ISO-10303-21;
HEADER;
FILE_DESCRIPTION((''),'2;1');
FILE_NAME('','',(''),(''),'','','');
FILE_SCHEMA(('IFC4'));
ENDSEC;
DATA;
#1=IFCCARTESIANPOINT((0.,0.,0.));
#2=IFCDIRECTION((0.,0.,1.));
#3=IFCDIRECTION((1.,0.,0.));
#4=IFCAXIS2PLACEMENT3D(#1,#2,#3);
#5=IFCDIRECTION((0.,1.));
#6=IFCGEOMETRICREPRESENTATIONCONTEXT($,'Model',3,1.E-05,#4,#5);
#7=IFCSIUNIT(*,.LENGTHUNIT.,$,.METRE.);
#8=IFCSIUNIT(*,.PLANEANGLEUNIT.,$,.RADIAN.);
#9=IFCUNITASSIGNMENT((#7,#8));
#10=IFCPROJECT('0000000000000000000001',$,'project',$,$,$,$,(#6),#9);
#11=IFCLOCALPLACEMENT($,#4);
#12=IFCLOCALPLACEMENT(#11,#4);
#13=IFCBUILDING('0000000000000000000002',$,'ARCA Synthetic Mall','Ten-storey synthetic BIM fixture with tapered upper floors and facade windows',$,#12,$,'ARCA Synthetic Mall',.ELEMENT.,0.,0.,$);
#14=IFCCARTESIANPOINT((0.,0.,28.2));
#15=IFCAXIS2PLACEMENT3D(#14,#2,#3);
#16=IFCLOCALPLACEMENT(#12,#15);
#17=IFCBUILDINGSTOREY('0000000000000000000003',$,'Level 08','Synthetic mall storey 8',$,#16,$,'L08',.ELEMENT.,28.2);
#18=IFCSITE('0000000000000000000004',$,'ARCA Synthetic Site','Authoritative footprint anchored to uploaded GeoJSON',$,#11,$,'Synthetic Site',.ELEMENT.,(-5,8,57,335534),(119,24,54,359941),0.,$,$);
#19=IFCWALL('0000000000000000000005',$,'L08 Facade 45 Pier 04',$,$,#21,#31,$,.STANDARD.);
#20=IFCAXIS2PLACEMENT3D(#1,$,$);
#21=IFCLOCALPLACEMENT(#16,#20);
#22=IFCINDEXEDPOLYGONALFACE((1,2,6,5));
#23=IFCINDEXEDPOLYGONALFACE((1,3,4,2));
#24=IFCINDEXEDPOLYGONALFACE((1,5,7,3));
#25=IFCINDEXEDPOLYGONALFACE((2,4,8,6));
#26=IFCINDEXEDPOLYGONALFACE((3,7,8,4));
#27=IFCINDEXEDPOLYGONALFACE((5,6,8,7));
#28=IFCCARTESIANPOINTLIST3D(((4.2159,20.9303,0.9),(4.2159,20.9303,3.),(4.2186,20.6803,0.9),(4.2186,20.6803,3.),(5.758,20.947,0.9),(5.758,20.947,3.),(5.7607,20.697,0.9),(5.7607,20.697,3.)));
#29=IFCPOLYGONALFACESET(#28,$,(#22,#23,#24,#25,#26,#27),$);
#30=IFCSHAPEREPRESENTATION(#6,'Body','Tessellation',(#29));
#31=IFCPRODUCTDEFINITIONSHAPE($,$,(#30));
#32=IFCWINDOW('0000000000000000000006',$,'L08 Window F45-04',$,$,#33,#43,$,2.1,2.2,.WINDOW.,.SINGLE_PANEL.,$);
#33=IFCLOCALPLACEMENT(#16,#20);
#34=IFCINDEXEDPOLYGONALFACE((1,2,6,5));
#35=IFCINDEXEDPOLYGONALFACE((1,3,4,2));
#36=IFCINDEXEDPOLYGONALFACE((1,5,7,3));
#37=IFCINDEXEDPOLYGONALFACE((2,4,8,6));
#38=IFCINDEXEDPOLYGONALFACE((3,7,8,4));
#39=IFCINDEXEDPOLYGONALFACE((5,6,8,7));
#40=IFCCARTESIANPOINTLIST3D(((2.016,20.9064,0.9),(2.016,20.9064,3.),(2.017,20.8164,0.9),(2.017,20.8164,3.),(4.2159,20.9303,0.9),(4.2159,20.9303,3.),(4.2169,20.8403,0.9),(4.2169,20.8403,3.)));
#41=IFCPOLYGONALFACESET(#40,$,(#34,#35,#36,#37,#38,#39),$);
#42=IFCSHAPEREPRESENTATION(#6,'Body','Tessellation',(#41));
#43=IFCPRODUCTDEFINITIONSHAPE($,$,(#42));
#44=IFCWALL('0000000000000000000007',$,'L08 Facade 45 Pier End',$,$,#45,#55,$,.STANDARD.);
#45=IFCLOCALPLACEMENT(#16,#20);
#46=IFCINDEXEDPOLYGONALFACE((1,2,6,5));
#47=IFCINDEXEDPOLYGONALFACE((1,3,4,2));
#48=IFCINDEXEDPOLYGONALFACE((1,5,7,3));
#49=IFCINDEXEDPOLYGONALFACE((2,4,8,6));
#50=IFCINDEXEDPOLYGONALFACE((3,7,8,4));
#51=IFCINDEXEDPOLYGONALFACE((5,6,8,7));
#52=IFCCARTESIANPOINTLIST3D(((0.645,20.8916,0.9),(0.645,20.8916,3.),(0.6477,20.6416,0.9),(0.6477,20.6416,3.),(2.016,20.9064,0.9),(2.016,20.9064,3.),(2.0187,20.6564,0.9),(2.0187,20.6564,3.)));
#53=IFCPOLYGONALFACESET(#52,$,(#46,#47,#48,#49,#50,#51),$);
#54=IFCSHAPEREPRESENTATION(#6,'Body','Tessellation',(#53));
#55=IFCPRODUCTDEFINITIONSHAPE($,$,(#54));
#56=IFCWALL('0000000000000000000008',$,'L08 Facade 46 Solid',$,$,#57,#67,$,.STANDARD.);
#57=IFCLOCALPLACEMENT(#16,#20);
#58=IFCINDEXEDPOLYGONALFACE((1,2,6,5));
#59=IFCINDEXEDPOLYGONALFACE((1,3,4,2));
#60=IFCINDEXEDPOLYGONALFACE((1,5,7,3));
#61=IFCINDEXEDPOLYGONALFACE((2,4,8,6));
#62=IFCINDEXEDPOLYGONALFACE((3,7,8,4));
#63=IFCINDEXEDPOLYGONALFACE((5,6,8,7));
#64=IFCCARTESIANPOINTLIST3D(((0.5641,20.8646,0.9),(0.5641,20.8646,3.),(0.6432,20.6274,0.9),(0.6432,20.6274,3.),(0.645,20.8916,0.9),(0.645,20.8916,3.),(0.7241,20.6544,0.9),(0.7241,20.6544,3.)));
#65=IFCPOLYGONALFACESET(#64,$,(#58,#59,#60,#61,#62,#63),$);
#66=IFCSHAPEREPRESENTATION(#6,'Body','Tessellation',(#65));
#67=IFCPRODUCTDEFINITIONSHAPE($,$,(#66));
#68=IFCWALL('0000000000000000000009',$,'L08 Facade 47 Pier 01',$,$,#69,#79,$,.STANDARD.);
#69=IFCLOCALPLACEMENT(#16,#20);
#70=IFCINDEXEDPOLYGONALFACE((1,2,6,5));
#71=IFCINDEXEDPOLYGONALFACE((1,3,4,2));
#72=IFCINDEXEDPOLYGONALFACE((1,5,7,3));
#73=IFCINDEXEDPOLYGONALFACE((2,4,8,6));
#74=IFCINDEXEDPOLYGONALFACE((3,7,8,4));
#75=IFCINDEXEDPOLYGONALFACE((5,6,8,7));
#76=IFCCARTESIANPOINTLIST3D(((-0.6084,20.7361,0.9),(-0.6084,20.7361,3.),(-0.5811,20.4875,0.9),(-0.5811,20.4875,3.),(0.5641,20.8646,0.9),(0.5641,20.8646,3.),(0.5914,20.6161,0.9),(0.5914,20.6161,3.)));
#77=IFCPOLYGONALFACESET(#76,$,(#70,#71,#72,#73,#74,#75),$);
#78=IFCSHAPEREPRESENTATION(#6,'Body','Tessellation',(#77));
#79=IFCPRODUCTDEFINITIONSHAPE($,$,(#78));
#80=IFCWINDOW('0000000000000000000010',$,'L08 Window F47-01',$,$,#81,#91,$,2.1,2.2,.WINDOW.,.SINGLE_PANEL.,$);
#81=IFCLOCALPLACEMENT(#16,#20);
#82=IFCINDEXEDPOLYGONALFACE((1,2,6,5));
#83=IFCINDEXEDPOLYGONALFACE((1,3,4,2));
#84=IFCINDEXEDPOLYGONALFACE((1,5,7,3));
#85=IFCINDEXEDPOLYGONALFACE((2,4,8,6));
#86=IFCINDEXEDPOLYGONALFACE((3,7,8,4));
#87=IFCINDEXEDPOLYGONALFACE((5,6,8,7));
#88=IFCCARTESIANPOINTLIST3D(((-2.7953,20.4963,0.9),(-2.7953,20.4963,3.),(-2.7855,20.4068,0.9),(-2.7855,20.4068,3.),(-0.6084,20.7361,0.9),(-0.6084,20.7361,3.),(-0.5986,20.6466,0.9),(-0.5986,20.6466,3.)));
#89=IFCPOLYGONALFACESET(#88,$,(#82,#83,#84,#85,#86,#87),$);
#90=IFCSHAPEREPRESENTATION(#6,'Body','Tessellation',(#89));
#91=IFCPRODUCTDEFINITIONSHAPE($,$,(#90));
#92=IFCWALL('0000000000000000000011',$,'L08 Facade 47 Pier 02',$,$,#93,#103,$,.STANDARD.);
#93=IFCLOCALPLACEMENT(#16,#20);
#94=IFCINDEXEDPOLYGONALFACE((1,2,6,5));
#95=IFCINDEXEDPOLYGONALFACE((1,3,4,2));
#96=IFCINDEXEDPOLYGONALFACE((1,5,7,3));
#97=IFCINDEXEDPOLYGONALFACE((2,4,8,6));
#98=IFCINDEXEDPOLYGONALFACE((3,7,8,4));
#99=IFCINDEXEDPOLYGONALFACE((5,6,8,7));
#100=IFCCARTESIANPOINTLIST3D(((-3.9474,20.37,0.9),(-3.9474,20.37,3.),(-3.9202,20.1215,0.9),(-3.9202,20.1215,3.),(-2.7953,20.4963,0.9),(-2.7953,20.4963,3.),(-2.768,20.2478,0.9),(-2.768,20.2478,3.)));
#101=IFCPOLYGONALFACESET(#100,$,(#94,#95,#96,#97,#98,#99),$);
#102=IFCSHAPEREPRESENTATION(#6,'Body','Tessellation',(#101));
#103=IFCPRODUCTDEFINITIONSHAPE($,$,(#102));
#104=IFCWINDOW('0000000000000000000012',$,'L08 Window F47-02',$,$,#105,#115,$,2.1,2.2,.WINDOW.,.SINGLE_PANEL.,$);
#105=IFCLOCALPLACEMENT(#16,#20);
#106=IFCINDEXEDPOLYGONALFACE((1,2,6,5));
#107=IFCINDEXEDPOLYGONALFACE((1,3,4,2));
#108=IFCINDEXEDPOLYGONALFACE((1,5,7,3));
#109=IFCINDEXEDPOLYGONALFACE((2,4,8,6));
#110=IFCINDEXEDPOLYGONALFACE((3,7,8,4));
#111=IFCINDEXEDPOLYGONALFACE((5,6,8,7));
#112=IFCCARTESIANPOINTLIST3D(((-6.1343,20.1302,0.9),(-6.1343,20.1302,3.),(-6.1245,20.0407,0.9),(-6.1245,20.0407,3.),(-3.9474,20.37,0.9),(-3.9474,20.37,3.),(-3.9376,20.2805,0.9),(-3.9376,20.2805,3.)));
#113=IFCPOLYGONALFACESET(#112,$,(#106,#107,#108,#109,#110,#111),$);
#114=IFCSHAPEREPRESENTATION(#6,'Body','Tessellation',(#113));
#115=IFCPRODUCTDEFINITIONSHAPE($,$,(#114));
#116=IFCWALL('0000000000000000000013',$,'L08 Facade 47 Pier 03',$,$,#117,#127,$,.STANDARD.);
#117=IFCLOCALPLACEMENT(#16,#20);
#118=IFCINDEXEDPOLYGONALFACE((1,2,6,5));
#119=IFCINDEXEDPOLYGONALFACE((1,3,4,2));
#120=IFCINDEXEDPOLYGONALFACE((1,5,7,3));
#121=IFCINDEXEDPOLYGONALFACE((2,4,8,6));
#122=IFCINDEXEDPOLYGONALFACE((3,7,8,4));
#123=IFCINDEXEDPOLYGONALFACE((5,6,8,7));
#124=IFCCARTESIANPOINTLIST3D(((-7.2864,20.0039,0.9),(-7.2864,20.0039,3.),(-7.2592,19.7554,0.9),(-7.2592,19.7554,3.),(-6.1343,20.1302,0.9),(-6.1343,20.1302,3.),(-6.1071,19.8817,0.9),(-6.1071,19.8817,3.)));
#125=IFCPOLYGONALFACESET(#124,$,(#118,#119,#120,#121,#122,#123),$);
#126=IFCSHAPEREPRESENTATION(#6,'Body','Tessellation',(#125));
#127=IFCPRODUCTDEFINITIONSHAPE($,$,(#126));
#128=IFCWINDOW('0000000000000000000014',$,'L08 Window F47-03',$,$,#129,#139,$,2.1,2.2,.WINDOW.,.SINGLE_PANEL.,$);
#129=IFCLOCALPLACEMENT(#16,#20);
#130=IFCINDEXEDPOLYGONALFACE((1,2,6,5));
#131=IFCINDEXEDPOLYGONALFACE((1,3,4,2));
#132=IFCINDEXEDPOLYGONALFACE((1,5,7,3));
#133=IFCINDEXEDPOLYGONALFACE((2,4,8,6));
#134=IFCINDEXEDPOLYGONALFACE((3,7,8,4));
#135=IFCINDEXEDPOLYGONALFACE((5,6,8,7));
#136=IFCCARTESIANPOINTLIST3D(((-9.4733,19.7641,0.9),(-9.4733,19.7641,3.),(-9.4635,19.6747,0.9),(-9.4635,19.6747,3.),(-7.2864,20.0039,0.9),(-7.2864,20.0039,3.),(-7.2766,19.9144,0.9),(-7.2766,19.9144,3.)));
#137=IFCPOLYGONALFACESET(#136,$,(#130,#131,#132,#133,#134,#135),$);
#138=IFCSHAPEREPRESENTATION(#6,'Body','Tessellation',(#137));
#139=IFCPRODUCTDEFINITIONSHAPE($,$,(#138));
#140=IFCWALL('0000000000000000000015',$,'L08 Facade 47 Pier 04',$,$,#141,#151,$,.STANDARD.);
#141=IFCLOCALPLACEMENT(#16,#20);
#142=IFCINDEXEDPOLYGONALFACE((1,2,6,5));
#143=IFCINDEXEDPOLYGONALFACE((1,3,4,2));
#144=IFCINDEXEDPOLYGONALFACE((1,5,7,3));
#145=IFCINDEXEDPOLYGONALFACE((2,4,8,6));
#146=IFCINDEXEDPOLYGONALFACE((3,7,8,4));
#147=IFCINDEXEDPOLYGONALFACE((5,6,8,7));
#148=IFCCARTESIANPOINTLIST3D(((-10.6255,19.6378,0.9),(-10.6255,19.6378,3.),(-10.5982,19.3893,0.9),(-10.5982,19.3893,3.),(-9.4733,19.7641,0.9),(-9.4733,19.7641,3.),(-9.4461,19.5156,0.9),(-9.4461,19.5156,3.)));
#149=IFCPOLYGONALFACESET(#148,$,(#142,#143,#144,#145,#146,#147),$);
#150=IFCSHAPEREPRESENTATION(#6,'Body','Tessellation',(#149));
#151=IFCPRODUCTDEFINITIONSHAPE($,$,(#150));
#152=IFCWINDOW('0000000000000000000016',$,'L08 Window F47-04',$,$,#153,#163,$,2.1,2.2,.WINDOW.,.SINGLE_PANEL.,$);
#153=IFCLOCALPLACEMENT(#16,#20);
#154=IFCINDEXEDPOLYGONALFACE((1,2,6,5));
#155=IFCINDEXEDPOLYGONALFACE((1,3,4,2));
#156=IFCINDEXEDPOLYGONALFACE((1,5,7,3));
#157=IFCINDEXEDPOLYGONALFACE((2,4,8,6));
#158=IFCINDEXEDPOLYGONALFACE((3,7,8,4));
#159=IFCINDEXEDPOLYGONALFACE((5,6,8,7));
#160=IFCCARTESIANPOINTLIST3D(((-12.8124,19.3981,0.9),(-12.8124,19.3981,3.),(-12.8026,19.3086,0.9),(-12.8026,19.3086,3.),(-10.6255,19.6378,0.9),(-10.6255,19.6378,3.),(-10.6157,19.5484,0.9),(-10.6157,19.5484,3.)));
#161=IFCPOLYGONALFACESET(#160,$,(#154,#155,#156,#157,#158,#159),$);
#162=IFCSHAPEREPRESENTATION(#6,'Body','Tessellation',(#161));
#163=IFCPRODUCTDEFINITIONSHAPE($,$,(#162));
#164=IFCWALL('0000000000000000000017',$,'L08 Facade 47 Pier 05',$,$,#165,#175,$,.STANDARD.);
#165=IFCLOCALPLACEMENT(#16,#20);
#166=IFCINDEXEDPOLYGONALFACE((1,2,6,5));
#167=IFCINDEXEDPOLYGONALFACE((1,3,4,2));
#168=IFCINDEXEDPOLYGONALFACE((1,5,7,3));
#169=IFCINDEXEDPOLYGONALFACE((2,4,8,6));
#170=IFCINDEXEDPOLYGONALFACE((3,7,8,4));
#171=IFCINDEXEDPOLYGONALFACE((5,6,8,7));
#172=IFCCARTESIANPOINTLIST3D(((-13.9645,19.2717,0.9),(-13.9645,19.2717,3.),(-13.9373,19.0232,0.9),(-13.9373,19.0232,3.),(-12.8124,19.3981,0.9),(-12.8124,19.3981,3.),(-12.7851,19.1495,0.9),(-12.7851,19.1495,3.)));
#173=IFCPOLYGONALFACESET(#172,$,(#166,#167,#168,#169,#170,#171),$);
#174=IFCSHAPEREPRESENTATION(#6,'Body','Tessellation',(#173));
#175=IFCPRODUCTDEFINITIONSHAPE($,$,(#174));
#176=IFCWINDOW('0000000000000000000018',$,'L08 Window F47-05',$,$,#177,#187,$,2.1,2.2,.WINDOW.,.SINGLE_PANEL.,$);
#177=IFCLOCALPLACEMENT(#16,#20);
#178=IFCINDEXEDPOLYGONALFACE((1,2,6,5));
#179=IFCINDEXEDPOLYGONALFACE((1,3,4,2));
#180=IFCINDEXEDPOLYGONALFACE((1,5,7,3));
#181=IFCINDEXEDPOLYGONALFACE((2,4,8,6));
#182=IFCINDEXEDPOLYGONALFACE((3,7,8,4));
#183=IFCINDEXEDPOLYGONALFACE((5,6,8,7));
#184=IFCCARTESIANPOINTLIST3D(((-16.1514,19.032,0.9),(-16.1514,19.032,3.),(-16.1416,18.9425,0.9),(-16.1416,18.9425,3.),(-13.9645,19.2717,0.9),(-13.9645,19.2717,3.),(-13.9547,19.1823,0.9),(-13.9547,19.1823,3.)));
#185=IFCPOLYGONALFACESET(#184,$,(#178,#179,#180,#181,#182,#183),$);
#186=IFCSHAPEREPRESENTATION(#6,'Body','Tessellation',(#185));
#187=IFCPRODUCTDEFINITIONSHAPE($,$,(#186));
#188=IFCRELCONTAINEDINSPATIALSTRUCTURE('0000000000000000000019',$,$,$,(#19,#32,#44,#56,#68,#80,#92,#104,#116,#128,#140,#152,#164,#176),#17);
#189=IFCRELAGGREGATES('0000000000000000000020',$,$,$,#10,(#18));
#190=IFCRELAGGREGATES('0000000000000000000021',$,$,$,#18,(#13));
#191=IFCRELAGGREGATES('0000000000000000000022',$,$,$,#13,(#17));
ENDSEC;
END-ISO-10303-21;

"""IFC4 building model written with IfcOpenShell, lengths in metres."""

from ifc_helpers import new_model, si_unit, direction, frame, origin_with_axes, place, context, project, spatial, polyline, outline, extrude, element, save


model = new_model("IFC4")

# Units and contexts
model_context = context("Model", 3, precision=1e-05, world=origin_with_axes(), true_north=direction((0.0, 1.0)))
ifc_project = project(units=[si_unit("LENGTHUNIT", "METRE"), si_unit("PLANEANGLEUNIT", "RADIAN")], contexts=[model_context])

# Site, building, storey
site_placement = place(None, origin_with_axes())
site = spatial("IfcSite", under=ifc_project, at=site_placement, Name="ARCA Synthetic Site", Description="Authoritative footprint anchored to uploaded GeoJSON", LongName="Synthetic Site", CompositionType="ELEMENT", RefLatitude=(-5, 8, 57, 335534), RefLongitude=(119, 24, 54, 359941), RefElevation=0.0)
building_placement = place(site_placement, origin_with_axes())
building = spatial("IfcBuilding", under=site, at=building_placement, Name="ARCA Synthetic Mall", Description="Ten-storey synthetic BIM fixture with tapered upper floors and facade windows", LongName="ARCA Synthetic Mall", CompositionType="ELEMENT", ElevationOfRefHeight=0.0, ElevationOfTerrain=0.0)
storey_placement = place(building_placement, frame((0.0, 0.0, 28.2), z_axis=(0.0, 0.0, 1.0), x_axis=(1.0, 0.0, 0.0)))
storey = spatial("IfcBuildingStorey", under=building, at=storey_placement, Name="Level 08", Description="Synthetic mall storey 8", LongName="L08", CompositionType="ELEMENT", Elevation=28.2)

# Wall
wall_1_placement = place(storey_placement, frame((0.0, 0.0, 0.9), z_axis=(0.0, 0.0, 1.0), x_axis=(1.0, 0.0, 0.0)))
element("IfcWall", 1, at=wall_1_placement, inside=storey, Name="L08 Facade 45 Pier 04", PredefinedType="STANDARD", context=model_context, shape_type="SweptSolid", body=[
    extrude(outline(polyline([(5.758, 20.947), (4.2159, 20.9303), (4.2186, 20.6803), (5.7607, 20.697), (5.758, 20.947)])), origin_with_axes(), (0.0, 0.0, 1.0), 2.1),
])

# Window
window_1_placement = place(storey_placement, frame((0.0, 0.0, 0.9), z_axis=(0.0, 0.0, 1.0), x_axis=(1.0, 0.0, 0.0)))
element("IfcWindow", 2, at=window_1_placement, inside=storey, Name="L08 Window F45-04", OverallHeight=2.1, OverallWidth=2.2, PartitioningType="SINGLE_PANEL", PredefinedType="WINDOW", context=model_context, shape_type="SweptSolid", body=[
    extrude(outline(polyline([(4.2159, 20.9303), (2.016, 20.9064), (2.017, 20.8164), (4.2169, 20.8403), (4.2159, 20.9303)])), origin_with_axes(), (0.0, 0.0, 1.0), 2.1),
])

# Walls
wall_2_placement = place(storey_placement, frame((0.0, 0.0, 0.9), z_axis=(0.0, 0.0, 1.0), x_axis=(1.0, 0.0, 0.0)))
element("IfcWall", 3, at=wall_2_placement, inside=storey, Name="L08 Facade 45 Pier End", PredefinedType="STANDARD", context=model_context, shape_type="SweptSolid", body=[
    extrude(outline(polyline([(2.016, 20.9064), (0.645, 20.8916), (0.6477, 20.6416), (2.0187, 20.6564), (2.016, 20.9064)])), origin_with_axes(), (0.0, 0.0, 1.0), 2.1),
])
wall_3_placement = place(storey_placement, frame((0.0, 0.0, 0.9), z_axis=(0.0, 0.0, 1.0), x_axis=(1.0, 0.0, 0.0)))
element("IfcWall", 4, at=wall_3_placement, inside=storey, Name="L08 Facade 46 Solid", PredefinedType="STANDARD", context=model_context, shape_type="SweptSolid", body=[
    extrude(outline(polyline([(0.645, 20.8916), (0.5641, 20.8646), (0.6432, 20.6274), (0.7241, 20.6544), (0.645, 20.8916)])), origin_with_axes(), (0.0, 0.0, 1.0), 2.1),
])
wall_4_placement = place(storey_placement, frame((0.0, 0.0, 0.9), z_axis=(0.0, 0.0, 1.0), x_axis=(1.0, 0.0, 0.0)))
element("IfcWall", 5, at=wall_4_placement, inside=storey, Name="L08 Facade 47 Pier 01", PredefinedType="STANDARD", context=model_context, shape_type="SweptSolid", body=[
    extrude(outline(polyline([(0.5641, 20.8646), (-0.6084, 20.7361), (-0.5811, 20.4875), (0.5914, 20.6161), (0.5641, 20.8646)])), origin_with_axes(), (0.0, 0.0, 1.0), 2.1),
])

# Window
window_2_placement = place(storey_placement, frame((0.0, 0.0, 0.9), z_axis=(0.0, 0.0, 1.0), x_axis=(1.0, 0.0, 0.0)))
element("IfcWindow", 6, at=window_2_placement, inside=storey, Name="L08 Window F47-01", OverallHeight=2.1, OverallWidth=2.2, PartitioningType="SINGLE_PANEL", PredefinedType="WINDOW", context=model_context, shape_type="SweptSolid", body=[
    extrude(outline(polyline([(-0.6084, 20.7361), (-2.7953, 20.4963), (-2.7855, 20.4068), (-0.5986, 20.6466), (-0.6084, 20.7361)])), origin_with_axes(), (0.0, 0.0, 1.0), 2.1),
])

# Wall
wall_5_placement = place(storey_placement, frame((0.0, 0.0, 0.9), z_axis=(0.0, 0.0, 1.0), x_axis=(1.0, 0.0, 0.0)))
element("IfcWall", 7, at=wall_5_placement, inside=storey, Name="L08 Facade 47 Pier 02", PredefinedType="STANDARD", context=model_context, shape_type="SweptSolid", body=[
    extrude(outline(polyline([(-2.7953, 20.4963), (-3.9474, 20.37), (-3.9202, 20.1215), (-2.768, 20.2478), (-2.7953, 20.4963)])), origin_with_axes(), (0.0, 0.0, 1.0), 2.1),
])

# Window
window_3_placement = place(storey_placement, frame((0.0, 0.0, 0.9), z_axis=(0.0, 0.0, 1.0), x_axis=(1.0, 0.0, 0.0)))
element("IfcWindow", 8, at=window_3_placement, inside=storey, Name="L08 Window F47-02", OverallHeight=2.1, OverallWidth=2.2, PartitioningType="SINGLE_PANEL", PredefinedType="WINDOW", context=model_context, shape_type="SweptSolid", body=[
    extrude(outline(polyline([(-3.9474, 20.37), (-6.1343, 20.1302), (-6.1245, 20.0407), (-3.9376, 20.2805), (-3.9474, 20.37)])), origin_with_axes(), (0.0, 0.0, 1.0), 2.1),
])

# Wall
wall_6_placement = place(storey_placement, frame((0.0, 0.0, 0.9), z_axis=(0.0, 0.0, 1.0), x_axis=(1.0, 0.0, 0.0)))
element("IfcWall", 9, at=wall_6_placement, inside=storey, Name="L08 Facade 47 Pier 03", PredefinedType="STANDARD", context=model_context, shape_type="SweptSolid", body=[
    extrude(outline(polyline([(-6.1343, 20.1302), (-7.2864, 20.0039), (-7.2592, 19.7554), (-6.1071, 19.8817), (-6.1343, 20.1302)])), origin_with_axes(), (0.0, 0.0, 1.0), 2.1),
])

# Window
window_4_placement = place(storey_placement, frame((0.0, 0.0, 0.9), z_axis=(0.0, 0.0, 1.0), x_axis=(1.0, 0.0, 0.0)))
element("IfcWindow", 10, at=window_4_placement, inside=storey, Name="L08 Window F47-03", OverallHeight=2.1, OverallWidth=2.2, PartitioningType="SINGLE_PANEL", PredefinedType="WINDOW", context=model_context, shape_type="SweptSolid", body=[
    extrude(outline(polyline([(-7.2864, 20.0039), (-9.4733, 19.7641), (-9.4635, 19.6747), (-7.2766, 19.9144), (-7.2864, 20.0039)])), origin_with_axes(), (0.0, 0.0, 1.0), 2.1),
])

# Wall
wall_7_placement = place(storey_placement, frame((0.0, 0.0, 0.9), z_axis=(0.0, 0.0, 1.0), x_axis=(1.0, 0.0, 0.0)))
element("IfcWall", 11, at=wall_7_placement, inside=storey, Name="L08 Facade 47 Pier 04", PredefinedType="STANDARD", context=model_context, shape_type="SweptSolid", body=[
    extrude(outline(polyline([(-9.4733, 19.7641), (-10.6255, 19.6378), (-10.5982, 19.3893), (-9.4461, 19.5156), (-9.4733, 19.7641)])), origin_with_axes(), (0.0, 0.0, 1.0), 2.1),
])

# Window
window_5_placement = place(storey_placement, frame((0.0, 0.0, 0.9), z_axis=(0.0, 0.0, 1.0), x_axis=(1.0, 0.0, 0.0)))
element("IfcWindow", 12, at=window_5_placement, inside=storey, Name="L08 Window F47-04", OverallHeight=2.1, OverallWidth=2.2, PartitioningType="SINGLE_PANEL", PredefinedType="WINDOW", context=model_context, shape_type="SweptSolid", body=[
    extrude(outline(polyline([(-10.6255, 19.6378), (-12.8124, 19.3981), (-12.8026, 19.3086), (-10.6157, 19.5483), (-10.6255, 19.6378)])), origin_with_axes(), (0.0, 0.0, 1.0), 2.1),
])

# Wall
wall_8_placement = place(storey_placement, frame((0.0, 0.0, 0.9), z_axis=(0.0, 0.0, 1.0), x_axis=(1.0, 0.0, 0.0)))
element("IfcWall", 13, at=wall_8_placement, inside=storey, Name="L08 Facade 47 Pier 05", PredefinedType="STANDARD", context=model_context, shape_type="SweptSolid", body=[
    extrude(outline(polyline([(-12.8124, 19.3981), (-13.9645, 19.2717), (-13.9373, 19.0232), (-12.7851, 19.1495), (-12.8124, 19.3981)])), origin_with_axes(), (0.0, 0.0, 1.0), 2.1),
])

# Window
window_6_placement = place(storey_placement, frame((0.0, 0.0, 0.9), z_axis=(0.0, 0.0, 1.0), x_axis=(1.0, 0.0, 0.0)))
element("IfcWindow", 14, at=window_6_placement, inside=storey, Name="L08 Window F47-05", OverallHeight=2.1, OverallWidth=2.2, PartitioningType="SINGLE_PANEL", PredefinedType="WINDOW", context=model_context, shape_type="SweptSolid", body=[
    extrude(outline(polyline([(-13.9645, 19.2717), (-16.1514, 19.032), (-16.1416, 18.9425), (-13.9547, 19.1823), (-13.9645, 19.2717)])), origin_with_axes(), (0.0, 0.0, 1.0), 2.1),
])

save(model, "model.ifc")
